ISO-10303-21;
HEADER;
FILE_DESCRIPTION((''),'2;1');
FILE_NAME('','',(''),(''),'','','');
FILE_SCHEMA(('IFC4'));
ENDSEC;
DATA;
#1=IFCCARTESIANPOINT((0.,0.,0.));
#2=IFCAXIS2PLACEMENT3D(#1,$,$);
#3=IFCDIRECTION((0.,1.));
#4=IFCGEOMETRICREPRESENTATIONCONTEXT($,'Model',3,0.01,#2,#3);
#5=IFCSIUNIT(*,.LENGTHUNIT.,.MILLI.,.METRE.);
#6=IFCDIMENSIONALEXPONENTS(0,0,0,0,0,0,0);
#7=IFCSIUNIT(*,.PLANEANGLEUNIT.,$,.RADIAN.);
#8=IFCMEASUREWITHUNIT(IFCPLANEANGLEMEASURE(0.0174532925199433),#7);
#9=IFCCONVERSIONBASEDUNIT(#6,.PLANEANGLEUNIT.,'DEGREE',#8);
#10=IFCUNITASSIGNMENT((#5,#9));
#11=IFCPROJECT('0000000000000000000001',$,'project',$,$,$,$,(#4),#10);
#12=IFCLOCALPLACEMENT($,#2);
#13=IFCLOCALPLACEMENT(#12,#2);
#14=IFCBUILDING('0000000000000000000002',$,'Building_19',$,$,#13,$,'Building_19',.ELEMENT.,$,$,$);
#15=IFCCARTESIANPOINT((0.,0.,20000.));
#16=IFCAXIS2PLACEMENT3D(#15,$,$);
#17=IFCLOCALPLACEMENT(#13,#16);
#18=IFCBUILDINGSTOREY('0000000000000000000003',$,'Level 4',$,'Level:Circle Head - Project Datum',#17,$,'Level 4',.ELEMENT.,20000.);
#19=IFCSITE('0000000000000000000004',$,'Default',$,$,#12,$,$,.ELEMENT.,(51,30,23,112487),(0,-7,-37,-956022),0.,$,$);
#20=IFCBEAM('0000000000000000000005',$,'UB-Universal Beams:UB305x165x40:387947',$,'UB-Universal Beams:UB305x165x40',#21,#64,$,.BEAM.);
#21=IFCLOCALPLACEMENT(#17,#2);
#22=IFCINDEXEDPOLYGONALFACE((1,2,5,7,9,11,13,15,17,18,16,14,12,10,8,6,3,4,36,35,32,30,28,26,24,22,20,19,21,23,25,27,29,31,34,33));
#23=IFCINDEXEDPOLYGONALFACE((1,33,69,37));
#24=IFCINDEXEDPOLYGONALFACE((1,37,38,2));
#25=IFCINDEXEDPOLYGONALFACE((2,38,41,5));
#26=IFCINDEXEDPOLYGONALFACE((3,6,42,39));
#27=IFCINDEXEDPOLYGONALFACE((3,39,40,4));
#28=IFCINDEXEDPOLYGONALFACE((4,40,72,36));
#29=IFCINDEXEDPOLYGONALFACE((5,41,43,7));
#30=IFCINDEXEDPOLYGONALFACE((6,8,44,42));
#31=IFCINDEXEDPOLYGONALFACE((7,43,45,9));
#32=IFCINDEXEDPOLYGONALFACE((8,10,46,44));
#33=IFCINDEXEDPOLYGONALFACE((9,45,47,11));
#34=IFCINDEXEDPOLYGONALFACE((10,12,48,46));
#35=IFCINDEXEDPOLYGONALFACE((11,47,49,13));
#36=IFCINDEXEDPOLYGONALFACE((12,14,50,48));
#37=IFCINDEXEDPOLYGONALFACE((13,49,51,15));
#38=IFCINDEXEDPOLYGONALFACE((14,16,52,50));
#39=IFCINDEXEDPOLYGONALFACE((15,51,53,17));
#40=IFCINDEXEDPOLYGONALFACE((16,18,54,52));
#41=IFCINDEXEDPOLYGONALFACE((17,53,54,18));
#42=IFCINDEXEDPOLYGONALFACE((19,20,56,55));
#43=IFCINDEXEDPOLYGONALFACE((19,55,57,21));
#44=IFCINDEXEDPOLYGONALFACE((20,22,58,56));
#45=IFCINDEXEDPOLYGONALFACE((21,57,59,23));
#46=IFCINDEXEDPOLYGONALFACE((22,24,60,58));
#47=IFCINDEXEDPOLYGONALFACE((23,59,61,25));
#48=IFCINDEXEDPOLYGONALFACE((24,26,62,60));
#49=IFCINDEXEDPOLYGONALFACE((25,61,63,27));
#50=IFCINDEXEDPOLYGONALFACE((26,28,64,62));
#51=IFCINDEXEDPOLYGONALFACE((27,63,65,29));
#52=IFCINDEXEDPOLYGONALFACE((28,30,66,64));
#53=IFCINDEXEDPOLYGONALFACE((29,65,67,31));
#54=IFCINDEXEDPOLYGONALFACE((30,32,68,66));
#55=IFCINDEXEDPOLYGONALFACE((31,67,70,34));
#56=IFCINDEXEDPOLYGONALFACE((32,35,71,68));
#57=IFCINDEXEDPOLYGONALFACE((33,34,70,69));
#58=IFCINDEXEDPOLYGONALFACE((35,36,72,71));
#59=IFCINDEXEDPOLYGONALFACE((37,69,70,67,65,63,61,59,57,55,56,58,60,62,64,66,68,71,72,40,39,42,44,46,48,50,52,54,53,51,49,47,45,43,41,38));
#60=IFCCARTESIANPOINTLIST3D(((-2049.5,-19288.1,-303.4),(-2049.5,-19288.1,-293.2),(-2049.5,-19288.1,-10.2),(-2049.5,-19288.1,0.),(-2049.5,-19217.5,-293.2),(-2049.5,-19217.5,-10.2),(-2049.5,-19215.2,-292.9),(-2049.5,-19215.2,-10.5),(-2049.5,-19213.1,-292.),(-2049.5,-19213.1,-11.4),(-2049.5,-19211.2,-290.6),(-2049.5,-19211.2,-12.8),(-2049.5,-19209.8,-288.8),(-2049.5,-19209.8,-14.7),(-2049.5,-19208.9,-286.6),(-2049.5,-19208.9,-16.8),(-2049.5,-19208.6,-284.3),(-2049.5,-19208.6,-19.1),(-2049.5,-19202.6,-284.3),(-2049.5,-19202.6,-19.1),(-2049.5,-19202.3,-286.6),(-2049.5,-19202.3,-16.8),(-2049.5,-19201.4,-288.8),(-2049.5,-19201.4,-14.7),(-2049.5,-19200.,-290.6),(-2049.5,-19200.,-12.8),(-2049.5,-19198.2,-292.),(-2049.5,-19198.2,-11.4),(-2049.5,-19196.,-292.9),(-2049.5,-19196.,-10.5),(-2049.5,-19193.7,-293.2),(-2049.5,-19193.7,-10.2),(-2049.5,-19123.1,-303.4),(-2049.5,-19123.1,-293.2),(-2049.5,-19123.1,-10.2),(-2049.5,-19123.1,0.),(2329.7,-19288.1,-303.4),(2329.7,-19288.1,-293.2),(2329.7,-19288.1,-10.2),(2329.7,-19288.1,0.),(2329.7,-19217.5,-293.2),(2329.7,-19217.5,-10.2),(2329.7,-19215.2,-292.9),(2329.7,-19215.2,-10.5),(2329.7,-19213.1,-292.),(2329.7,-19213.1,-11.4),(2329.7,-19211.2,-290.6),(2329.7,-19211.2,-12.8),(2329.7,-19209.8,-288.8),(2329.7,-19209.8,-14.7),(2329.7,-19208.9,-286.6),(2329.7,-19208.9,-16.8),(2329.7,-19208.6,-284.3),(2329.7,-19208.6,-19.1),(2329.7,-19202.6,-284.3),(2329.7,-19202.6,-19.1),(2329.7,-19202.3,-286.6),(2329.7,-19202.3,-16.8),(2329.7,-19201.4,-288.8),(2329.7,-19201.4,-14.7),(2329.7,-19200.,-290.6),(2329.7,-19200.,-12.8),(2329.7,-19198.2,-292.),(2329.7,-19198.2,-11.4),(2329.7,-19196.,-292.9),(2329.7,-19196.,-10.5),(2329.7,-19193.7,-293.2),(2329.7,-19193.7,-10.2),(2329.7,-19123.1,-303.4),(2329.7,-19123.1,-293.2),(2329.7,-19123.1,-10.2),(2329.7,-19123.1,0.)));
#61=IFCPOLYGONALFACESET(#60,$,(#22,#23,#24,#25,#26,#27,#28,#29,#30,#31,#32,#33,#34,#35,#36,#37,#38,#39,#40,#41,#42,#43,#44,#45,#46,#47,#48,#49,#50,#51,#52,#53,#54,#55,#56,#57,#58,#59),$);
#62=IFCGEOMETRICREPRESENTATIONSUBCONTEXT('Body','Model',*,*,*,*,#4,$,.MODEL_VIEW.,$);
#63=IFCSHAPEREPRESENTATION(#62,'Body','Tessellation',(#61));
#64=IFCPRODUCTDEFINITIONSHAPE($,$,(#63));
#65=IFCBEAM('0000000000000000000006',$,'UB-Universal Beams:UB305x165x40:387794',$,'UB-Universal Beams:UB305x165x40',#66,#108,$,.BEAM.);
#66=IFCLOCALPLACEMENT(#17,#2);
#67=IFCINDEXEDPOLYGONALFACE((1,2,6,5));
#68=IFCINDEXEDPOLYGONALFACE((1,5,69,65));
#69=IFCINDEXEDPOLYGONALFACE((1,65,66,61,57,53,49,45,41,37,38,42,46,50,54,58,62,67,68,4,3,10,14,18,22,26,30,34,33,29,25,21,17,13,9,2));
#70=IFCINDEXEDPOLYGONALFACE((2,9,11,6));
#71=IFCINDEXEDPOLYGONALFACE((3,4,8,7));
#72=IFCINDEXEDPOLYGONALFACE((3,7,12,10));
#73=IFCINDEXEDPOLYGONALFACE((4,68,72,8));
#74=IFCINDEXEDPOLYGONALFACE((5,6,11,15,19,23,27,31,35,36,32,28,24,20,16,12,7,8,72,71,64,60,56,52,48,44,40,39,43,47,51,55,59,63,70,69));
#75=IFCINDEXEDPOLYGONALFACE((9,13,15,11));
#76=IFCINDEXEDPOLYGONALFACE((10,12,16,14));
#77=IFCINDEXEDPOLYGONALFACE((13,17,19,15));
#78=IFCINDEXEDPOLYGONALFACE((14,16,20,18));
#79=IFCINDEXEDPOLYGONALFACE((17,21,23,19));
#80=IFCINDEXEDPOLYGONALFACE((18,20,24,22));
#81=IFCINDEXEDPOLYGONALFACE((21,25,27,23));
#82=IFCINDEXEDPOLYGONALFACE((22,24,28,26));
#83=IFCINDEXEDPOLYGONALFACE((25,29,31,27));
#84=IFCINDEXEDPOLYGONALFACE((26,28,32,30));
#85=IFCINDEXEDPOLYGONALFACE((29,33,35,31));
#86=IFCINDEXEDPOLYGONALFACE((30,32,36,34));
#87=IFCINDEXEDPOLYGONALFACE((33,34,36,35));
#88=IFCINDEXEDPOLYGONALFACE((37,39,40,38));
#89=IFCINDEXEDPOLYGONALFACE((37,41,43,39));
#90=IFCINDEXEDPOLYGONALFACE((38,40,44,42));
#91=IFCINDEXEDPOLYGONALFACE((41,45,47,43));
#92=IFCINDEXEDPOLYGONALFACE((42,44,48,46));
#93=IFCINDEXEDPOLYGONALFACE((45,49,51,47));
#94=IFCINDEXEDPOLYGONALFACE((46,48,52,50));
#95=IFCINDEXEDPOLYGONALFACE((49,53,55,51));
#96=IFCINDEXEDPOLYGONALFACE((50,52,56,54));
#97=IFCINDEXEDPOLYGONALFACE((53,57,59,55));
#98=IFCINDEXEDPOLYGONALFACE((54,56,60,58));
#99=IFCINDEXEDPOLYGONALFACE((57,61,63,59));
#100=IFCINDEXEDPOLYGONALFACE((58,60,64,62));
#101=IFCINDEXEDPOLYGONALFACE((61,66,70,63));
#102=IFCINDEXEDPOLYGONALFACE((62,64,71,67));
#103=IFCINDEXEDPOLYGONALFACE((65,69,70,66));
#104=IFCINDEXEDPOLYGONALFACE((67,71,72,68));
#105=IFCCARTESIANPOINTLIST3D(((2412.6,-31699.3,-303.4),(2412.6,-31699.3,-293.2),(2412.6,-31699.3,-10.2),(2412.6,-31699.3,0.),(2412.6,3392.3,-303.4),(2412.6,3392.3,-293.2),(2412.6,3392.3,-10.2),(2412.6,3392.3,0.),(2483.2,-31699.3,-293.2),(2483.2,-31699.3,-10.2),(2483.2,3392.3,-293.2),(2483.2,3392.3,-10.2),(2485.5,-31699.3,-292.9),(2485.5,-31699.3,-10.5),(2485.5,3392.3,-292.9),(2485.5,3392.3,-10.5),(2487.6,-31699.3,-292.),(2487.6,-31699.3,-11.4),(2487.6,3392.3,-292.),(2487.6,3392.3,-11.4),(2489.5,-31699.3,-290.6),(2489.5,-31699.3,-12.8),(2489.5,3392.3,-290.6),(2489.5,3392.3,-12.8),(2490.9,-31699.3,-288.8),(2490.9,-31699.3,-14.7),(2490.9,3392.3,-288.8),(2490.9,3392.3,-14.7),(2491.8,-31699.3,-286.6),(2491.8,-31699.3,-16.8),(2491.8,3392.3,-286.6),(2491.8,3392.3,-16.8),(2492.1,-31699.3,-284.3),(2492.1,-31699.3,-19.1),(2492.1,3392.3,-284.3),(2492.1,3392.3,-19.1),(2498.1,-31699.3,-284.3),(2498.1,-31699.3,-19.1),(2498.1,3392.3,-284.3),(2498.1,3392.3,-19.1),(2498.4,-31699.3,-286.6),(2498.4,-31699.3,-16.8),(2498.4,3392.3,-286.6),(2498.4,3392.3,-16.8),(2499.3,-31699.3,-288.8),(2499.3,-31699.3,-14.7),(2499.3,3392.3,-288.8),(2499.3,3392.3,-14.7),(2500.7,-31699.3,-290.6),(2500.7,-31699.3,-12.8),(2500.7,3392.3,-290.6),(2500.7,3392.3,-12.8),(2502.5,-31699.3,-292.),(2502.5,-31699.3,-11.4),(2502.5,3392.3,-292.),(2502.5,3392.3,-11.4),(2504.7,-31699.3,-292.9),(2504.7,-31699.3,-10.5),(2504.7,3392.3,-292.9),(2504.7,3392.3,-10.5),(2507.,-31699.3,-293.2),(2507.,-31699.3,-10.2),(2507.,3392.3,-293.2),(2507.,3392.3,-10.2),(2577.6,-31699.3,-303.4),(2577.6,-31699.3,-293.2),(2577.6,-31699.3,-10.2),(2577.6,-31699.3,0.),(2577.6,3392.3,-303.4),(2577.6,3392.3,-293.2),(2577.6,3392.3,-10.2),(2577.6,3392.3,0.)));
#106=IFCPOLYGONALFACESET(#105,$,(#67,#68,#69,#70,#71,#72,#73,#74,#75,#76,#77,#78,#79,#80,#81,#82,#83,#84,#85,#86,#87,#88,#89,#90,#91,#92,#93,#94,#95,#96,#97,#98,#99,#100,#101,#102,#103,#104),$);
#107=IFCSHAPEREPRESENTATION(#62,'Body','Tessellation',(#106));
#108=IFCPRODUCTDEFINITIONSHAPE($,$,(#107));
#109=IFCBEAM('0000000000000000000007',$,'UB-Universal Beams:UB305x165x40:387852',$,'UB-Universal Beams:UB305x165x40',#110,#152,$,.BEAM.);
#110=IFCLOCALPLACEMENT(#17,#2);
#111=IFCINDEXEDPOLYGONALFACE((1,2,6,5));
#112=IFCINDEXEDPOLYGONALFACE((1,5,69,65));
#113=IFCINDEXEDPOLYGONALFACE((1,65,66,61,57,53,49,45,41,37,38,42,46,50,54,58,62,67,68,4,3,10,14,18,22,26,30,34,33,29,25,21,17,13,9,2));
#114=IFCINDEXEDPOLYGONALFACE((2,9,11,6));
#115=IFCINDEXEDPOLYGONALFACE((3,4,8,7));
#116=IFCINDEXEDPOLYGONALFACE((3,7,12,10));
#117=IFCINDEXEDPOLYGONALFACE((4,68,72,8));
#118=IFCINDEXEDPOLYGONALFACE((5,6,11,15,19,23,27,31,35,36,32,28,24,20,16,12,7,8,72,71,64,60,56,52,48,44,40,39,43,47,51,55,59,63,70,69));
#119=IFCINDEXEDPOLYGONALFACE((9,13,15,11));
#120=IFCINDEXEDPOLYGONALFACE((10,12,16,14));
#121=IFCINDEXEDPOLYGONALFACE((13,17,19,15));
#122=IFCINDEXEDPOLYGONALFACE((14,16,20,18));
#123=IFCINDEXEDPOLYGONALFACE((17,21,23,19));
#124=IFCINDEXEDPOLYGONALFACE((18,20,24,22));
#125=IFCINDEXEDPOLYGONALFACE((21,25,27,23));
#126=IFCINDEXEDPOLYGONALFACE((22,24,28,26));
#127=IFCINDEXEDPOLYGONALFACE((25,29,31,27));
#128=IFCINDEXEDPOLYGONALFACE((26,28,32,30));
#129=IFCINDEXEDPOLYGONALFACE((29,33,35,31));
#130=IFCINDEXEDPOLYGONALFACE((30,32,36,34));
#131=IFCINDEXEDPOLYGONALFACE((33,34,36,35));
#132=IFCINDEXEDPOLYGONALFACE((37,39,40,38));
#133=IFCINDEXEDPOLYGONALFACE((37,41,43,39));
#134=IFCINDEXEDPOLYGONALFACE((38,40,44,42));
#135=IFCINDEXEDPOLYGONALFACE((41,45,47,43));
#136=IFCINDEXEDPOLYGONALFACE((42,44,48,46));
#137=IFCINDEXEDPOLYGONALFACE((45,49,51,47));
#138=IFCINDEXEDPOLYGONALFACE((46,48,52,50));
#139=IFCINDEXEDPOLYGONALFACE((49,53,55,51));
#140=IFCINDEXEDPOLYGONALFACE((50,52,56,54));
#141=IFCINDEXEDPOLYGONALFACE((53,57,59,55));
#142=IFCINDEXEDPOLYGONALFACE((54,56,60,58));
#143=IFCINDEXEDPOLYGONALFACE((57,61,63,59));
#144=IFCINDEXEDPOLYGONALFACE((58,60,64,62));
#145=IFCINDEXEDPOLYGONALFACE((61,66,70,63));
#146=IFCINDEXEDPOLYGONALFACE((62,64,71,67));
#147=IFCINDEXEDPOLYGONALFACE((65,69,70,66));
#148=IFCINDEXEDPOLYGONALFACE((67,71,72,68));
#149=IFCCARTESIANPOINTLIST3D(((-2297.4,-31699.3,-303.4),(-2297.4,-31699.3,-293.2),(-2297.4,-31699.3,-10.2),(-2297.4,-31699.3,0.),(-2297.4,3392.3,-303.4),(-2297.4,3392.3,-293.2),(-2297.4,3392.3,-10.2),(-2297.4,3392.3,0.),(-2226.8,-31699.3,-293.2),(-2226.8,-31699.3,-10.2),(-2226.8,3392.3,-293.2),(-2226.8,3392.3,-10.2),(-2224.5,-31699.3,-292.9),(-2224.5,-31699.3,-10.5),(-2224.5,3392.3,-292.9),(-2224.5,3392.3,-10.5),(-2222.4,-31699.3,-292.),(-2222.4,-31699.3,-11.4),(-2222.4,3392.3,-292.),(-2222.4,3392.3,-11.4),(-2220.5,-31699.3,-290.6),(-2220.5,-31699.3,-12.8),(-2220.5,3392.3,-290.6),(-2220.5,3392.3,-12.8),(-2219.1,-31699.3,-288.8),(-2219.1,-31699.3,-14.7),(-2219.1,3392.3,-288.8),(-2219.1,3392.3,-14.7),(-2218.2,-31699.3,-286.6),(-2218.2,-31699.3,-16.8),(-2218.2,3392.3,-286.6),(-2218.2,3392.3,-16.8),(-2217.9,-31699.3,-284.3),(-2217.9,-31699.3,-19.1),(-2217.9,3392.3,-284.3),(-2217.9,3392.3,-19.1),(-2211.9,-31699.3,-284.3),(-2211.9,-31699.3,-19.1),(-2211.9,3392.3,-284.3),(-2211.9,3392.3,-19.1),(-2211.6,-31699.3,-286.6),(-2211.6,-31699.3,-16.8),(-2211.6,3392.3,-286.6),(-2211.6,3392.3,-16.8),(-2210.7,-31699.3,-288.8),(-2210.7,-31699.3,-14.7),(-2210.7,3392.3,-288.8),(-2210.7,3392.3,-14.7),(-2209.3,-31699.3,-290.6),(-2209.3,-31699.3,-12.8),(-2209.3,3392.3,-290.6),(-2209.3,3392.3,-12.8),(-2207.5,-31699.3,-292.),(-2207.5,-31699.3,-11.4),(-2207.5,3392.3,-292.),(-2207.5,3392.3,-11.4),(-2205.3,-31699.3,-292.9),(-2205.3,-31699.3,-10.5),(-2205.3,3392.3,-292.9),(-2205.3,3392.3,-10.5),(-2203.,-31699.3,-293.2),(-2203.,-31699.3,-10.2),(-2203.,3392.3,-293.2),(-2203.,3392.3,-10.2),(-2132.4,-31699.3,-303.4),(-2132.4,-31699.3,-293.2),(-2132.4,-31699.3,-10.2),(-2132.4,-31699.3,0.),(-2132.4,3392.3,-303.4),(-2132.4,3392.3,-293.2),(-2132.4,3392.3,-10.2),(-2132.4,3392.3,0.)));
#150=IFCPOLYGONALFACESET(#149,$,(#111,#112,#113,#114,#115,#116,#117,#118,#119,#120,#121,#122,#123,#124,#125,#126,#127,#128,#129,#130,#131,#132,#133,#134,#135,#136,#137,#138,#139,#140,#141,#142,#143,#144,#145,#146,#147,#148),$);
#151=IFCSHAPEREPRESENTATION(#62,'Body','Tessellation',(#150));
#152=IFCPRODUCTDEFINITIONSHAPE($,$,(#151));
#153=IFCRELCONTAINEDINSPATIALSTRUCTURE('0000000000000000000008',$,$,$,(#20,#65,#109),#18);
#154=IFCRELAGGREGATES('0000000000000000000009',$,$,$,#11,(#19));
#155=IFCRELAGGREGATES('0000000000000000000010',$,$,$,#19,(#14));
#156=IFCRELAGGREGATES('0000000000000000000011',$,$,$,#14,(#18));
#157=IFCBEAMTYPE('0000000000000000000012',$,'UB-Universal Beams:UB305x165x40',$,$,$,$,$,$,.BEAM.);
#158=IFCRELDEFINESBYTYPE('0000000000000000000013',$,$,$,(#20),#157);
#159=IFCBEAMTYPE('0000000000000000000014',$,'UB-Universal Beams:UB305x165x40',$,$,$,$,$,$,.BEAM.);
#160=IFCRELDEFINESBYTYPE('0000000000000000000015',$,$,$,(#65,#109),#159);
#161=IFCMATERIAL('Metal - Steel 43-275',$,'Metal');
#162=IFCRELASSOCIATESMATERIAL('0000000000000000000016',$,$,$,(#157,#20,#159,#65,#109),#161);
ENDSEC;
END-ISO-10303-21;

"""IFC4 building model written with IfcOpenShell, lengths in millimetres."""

from ifc_helpers import new_model, entity, si_unit, converted_unit, direction, frame, origin, place, context, subcontext, project, spatial, line, arc, indexed_curve, outline, extrude, source, transform, mapped, material, type_object, type_shapes, element, save


model = new_model("IFC4")

# Units and contexts
model_context = context("Model", 3, precision=0.01, world=origin(), true_north=direction((0.0, 1.0)))
body_context = subcontext(model_context, "Body", "Model", "MODEL_VIEW")
ifc_project = project(units=[si_unit("LENGTHUNIT", "METRE", prefix="MILLI"), converted_unit("PLANEANGLEUNIT", "DEGREE", entity("IfcPlaneAngleMeasure", 0.0174532925199433), si_unit("PLANEANGLEUNIT", "RADIAN"), dimensions=[0, 0, 0, 0, 0, 0, 0])], contexts=[model_context])

# Site, building, storey
site_placement = place(None, origin())
site = spatial("IfcSite", under=ifc_project, at=site_placement, Name="Default", CompositionType="ELEMENT", RefLatitude=(51, 30, 23, 112487), RefLongitude=(0, -7, -37, -956022), RefElevation=0.0)
building_placement = place(site_placement, origin())
building = spatial("IfcBuilding", under=site, at=building_placement, Name="Building_19", LongName="Building_19", CompositionType="ELEMENT")
storey_placement = place(building_placement, frame((0.0, 0.0, 20000.0)))
storey = spatial("IfcBuildingStorey", under=building, at=storey_placement, Name="Level 4", ObjectType="Level:Circle Head - Project Datum", LongName="Level 4", CompositionType="ELEMENT", Elevation=20000.0)

# Beams
ifc_material_1 = material(Name="Metal - Steel 43-275", Category="Metal")
beam_type_1 = type_object("IfcBeamType", Name="UB-Universal Beams:UB305x165x40", PredefinedType="BEAM", material=ifc_material_1)
shared_shape_1 = source(origin(), body_context, "Body", "SweptSolid", [
    extrude(outline(indexed_curve([(-82.5, -141.5), (-82.5, -151.7), (82.5, -151.7), (82.5, -141.5), (11.9, -141.5), (5.6, -138.9), (3.0, -132.6), (3.0, 132.6), (5.6, 138.9), (11.9, 141.5), (82.5, 141.5), (82.5, 151.7), (-82.5, 151.7), (-82.5, 141.5), (-11.9, 141.5), (-5.6, 138.9), (-3.0, 132.6), (-3.0, -132.6), (-5.6, -138.9), (-11.9, -141.5)], segments=[line(1, 2, 3, 4, 5), arc(5, 6, 7), line(7, 8), arc(8, 9, 10), line(10, 11, 12, 13, 14, 15), arc(15, 16, 17), line(17, 18), arc(18, 19, 20), line(20, 1)], self_intersect=False)), frame((-2189.6, 0.0, 0.0), z_axis=(-1.0, 0.0, 0.0), x_axis=(0.0, -1.0, 0.0)), (0.0, 0.0, -1.0), 4379.2),
])
type_shapes(beam_type_1, [shared_shape_1])
for number, where, name in (
    (1, (140.1, -19205.6, -151.7), "UB-Universal Beams:UB305x165x40:387947"),
):
    element("IfcBeam", number, at=place(storey_placement, frame(where)), inside=storey, type_object=beam_type_1, material=ifc_material_1, Name=name, ObjectType="UB-Universal Beams:UB305x165x40", PredefinedType="BEAM", context=body_context, shape_type="MappedRepresentation", body=[
        mapped(shared_shape_1, transform((0.0, 0.0, 0.0), scale=1.0)),
    ])
beam_type_2 = type_object("IfcBeamType", Name="UB-Universal Beams:UB305x165x40", PredefinedType="BEAM", material=ifc_material_1)
shared_shape_2 = source(origin(), body_context, "Body", "SweptSolid", [
    extrude(outline(indexed_curve([(-82.5, -141.5), (-82.5, -151.7), (82.5, -151.7), (82.5, -141.5), (11.9, -141.5), (5.6, -138.9), (3.0, -132.6), (3.0, 132.6), (5.6, 138.9), (11.9, 141.5), (82.5, 141.5), (82.5, 151.7), (-82.5, 151.7), (-82.5, 141.5), (-11.9, 141.5), (-5.6, 138.9), (-3.0, 132.6), (-3.0, -132.6), (-5.6, -138.9), (-11.9, -141.5)], segments=[line(1, 2, 3, 4, 5), arc(5, 6, 7), line(7, 8), arc(8, 9, 10), line(10, 11, 12, 13, 14, 15), arc(15, 16, 17), line(17, 18), arc(18, 19, 20), line(20, 1)], self_intersect=False)), frame((-17545.8, 0.0, 0.0), z_axis=(-1.0, 0.0, 0.0), x_axis=(0.0, -1.0, 0.0)), (0.0, 0.0, -1.0), 35091.6),
])
type_shapes(beam_type_2, [shared_shape_2])
for number, where, z_axis, x_axis, name in (
    (2, (2495.1, -14153.5, -151.7), (0.0, 0.0, 1.0), (0.0, -1.0, 0.0), "UB-Universal Beams:UB305x165x40:387794"),
    (3, (-2214.9, -14153.5, -151.7), (0.0, 0.0, 1.0), (0.0, 1.0, 0.0), "UB-Universal Beams:UB305x165x40:387852"),
):
    element("IfcBeam", number, at=place(storey_placement, frame(where, z_axis=z_axis, x_axis=x_axis)), inside=storey, type_object=beam_type_2, material=ifc_material_1, Name=name, ObjectType="UB-Universal Beams:UB305x165x40", PredefinedType="BEAM", context=body_context, shape_type="MappedRepresentation", body=[
        mapped(shared_shape_2, transform((0.0, 0.0, 0.0), scale=1.0)),
    ])

save(model, "model.ifc")
